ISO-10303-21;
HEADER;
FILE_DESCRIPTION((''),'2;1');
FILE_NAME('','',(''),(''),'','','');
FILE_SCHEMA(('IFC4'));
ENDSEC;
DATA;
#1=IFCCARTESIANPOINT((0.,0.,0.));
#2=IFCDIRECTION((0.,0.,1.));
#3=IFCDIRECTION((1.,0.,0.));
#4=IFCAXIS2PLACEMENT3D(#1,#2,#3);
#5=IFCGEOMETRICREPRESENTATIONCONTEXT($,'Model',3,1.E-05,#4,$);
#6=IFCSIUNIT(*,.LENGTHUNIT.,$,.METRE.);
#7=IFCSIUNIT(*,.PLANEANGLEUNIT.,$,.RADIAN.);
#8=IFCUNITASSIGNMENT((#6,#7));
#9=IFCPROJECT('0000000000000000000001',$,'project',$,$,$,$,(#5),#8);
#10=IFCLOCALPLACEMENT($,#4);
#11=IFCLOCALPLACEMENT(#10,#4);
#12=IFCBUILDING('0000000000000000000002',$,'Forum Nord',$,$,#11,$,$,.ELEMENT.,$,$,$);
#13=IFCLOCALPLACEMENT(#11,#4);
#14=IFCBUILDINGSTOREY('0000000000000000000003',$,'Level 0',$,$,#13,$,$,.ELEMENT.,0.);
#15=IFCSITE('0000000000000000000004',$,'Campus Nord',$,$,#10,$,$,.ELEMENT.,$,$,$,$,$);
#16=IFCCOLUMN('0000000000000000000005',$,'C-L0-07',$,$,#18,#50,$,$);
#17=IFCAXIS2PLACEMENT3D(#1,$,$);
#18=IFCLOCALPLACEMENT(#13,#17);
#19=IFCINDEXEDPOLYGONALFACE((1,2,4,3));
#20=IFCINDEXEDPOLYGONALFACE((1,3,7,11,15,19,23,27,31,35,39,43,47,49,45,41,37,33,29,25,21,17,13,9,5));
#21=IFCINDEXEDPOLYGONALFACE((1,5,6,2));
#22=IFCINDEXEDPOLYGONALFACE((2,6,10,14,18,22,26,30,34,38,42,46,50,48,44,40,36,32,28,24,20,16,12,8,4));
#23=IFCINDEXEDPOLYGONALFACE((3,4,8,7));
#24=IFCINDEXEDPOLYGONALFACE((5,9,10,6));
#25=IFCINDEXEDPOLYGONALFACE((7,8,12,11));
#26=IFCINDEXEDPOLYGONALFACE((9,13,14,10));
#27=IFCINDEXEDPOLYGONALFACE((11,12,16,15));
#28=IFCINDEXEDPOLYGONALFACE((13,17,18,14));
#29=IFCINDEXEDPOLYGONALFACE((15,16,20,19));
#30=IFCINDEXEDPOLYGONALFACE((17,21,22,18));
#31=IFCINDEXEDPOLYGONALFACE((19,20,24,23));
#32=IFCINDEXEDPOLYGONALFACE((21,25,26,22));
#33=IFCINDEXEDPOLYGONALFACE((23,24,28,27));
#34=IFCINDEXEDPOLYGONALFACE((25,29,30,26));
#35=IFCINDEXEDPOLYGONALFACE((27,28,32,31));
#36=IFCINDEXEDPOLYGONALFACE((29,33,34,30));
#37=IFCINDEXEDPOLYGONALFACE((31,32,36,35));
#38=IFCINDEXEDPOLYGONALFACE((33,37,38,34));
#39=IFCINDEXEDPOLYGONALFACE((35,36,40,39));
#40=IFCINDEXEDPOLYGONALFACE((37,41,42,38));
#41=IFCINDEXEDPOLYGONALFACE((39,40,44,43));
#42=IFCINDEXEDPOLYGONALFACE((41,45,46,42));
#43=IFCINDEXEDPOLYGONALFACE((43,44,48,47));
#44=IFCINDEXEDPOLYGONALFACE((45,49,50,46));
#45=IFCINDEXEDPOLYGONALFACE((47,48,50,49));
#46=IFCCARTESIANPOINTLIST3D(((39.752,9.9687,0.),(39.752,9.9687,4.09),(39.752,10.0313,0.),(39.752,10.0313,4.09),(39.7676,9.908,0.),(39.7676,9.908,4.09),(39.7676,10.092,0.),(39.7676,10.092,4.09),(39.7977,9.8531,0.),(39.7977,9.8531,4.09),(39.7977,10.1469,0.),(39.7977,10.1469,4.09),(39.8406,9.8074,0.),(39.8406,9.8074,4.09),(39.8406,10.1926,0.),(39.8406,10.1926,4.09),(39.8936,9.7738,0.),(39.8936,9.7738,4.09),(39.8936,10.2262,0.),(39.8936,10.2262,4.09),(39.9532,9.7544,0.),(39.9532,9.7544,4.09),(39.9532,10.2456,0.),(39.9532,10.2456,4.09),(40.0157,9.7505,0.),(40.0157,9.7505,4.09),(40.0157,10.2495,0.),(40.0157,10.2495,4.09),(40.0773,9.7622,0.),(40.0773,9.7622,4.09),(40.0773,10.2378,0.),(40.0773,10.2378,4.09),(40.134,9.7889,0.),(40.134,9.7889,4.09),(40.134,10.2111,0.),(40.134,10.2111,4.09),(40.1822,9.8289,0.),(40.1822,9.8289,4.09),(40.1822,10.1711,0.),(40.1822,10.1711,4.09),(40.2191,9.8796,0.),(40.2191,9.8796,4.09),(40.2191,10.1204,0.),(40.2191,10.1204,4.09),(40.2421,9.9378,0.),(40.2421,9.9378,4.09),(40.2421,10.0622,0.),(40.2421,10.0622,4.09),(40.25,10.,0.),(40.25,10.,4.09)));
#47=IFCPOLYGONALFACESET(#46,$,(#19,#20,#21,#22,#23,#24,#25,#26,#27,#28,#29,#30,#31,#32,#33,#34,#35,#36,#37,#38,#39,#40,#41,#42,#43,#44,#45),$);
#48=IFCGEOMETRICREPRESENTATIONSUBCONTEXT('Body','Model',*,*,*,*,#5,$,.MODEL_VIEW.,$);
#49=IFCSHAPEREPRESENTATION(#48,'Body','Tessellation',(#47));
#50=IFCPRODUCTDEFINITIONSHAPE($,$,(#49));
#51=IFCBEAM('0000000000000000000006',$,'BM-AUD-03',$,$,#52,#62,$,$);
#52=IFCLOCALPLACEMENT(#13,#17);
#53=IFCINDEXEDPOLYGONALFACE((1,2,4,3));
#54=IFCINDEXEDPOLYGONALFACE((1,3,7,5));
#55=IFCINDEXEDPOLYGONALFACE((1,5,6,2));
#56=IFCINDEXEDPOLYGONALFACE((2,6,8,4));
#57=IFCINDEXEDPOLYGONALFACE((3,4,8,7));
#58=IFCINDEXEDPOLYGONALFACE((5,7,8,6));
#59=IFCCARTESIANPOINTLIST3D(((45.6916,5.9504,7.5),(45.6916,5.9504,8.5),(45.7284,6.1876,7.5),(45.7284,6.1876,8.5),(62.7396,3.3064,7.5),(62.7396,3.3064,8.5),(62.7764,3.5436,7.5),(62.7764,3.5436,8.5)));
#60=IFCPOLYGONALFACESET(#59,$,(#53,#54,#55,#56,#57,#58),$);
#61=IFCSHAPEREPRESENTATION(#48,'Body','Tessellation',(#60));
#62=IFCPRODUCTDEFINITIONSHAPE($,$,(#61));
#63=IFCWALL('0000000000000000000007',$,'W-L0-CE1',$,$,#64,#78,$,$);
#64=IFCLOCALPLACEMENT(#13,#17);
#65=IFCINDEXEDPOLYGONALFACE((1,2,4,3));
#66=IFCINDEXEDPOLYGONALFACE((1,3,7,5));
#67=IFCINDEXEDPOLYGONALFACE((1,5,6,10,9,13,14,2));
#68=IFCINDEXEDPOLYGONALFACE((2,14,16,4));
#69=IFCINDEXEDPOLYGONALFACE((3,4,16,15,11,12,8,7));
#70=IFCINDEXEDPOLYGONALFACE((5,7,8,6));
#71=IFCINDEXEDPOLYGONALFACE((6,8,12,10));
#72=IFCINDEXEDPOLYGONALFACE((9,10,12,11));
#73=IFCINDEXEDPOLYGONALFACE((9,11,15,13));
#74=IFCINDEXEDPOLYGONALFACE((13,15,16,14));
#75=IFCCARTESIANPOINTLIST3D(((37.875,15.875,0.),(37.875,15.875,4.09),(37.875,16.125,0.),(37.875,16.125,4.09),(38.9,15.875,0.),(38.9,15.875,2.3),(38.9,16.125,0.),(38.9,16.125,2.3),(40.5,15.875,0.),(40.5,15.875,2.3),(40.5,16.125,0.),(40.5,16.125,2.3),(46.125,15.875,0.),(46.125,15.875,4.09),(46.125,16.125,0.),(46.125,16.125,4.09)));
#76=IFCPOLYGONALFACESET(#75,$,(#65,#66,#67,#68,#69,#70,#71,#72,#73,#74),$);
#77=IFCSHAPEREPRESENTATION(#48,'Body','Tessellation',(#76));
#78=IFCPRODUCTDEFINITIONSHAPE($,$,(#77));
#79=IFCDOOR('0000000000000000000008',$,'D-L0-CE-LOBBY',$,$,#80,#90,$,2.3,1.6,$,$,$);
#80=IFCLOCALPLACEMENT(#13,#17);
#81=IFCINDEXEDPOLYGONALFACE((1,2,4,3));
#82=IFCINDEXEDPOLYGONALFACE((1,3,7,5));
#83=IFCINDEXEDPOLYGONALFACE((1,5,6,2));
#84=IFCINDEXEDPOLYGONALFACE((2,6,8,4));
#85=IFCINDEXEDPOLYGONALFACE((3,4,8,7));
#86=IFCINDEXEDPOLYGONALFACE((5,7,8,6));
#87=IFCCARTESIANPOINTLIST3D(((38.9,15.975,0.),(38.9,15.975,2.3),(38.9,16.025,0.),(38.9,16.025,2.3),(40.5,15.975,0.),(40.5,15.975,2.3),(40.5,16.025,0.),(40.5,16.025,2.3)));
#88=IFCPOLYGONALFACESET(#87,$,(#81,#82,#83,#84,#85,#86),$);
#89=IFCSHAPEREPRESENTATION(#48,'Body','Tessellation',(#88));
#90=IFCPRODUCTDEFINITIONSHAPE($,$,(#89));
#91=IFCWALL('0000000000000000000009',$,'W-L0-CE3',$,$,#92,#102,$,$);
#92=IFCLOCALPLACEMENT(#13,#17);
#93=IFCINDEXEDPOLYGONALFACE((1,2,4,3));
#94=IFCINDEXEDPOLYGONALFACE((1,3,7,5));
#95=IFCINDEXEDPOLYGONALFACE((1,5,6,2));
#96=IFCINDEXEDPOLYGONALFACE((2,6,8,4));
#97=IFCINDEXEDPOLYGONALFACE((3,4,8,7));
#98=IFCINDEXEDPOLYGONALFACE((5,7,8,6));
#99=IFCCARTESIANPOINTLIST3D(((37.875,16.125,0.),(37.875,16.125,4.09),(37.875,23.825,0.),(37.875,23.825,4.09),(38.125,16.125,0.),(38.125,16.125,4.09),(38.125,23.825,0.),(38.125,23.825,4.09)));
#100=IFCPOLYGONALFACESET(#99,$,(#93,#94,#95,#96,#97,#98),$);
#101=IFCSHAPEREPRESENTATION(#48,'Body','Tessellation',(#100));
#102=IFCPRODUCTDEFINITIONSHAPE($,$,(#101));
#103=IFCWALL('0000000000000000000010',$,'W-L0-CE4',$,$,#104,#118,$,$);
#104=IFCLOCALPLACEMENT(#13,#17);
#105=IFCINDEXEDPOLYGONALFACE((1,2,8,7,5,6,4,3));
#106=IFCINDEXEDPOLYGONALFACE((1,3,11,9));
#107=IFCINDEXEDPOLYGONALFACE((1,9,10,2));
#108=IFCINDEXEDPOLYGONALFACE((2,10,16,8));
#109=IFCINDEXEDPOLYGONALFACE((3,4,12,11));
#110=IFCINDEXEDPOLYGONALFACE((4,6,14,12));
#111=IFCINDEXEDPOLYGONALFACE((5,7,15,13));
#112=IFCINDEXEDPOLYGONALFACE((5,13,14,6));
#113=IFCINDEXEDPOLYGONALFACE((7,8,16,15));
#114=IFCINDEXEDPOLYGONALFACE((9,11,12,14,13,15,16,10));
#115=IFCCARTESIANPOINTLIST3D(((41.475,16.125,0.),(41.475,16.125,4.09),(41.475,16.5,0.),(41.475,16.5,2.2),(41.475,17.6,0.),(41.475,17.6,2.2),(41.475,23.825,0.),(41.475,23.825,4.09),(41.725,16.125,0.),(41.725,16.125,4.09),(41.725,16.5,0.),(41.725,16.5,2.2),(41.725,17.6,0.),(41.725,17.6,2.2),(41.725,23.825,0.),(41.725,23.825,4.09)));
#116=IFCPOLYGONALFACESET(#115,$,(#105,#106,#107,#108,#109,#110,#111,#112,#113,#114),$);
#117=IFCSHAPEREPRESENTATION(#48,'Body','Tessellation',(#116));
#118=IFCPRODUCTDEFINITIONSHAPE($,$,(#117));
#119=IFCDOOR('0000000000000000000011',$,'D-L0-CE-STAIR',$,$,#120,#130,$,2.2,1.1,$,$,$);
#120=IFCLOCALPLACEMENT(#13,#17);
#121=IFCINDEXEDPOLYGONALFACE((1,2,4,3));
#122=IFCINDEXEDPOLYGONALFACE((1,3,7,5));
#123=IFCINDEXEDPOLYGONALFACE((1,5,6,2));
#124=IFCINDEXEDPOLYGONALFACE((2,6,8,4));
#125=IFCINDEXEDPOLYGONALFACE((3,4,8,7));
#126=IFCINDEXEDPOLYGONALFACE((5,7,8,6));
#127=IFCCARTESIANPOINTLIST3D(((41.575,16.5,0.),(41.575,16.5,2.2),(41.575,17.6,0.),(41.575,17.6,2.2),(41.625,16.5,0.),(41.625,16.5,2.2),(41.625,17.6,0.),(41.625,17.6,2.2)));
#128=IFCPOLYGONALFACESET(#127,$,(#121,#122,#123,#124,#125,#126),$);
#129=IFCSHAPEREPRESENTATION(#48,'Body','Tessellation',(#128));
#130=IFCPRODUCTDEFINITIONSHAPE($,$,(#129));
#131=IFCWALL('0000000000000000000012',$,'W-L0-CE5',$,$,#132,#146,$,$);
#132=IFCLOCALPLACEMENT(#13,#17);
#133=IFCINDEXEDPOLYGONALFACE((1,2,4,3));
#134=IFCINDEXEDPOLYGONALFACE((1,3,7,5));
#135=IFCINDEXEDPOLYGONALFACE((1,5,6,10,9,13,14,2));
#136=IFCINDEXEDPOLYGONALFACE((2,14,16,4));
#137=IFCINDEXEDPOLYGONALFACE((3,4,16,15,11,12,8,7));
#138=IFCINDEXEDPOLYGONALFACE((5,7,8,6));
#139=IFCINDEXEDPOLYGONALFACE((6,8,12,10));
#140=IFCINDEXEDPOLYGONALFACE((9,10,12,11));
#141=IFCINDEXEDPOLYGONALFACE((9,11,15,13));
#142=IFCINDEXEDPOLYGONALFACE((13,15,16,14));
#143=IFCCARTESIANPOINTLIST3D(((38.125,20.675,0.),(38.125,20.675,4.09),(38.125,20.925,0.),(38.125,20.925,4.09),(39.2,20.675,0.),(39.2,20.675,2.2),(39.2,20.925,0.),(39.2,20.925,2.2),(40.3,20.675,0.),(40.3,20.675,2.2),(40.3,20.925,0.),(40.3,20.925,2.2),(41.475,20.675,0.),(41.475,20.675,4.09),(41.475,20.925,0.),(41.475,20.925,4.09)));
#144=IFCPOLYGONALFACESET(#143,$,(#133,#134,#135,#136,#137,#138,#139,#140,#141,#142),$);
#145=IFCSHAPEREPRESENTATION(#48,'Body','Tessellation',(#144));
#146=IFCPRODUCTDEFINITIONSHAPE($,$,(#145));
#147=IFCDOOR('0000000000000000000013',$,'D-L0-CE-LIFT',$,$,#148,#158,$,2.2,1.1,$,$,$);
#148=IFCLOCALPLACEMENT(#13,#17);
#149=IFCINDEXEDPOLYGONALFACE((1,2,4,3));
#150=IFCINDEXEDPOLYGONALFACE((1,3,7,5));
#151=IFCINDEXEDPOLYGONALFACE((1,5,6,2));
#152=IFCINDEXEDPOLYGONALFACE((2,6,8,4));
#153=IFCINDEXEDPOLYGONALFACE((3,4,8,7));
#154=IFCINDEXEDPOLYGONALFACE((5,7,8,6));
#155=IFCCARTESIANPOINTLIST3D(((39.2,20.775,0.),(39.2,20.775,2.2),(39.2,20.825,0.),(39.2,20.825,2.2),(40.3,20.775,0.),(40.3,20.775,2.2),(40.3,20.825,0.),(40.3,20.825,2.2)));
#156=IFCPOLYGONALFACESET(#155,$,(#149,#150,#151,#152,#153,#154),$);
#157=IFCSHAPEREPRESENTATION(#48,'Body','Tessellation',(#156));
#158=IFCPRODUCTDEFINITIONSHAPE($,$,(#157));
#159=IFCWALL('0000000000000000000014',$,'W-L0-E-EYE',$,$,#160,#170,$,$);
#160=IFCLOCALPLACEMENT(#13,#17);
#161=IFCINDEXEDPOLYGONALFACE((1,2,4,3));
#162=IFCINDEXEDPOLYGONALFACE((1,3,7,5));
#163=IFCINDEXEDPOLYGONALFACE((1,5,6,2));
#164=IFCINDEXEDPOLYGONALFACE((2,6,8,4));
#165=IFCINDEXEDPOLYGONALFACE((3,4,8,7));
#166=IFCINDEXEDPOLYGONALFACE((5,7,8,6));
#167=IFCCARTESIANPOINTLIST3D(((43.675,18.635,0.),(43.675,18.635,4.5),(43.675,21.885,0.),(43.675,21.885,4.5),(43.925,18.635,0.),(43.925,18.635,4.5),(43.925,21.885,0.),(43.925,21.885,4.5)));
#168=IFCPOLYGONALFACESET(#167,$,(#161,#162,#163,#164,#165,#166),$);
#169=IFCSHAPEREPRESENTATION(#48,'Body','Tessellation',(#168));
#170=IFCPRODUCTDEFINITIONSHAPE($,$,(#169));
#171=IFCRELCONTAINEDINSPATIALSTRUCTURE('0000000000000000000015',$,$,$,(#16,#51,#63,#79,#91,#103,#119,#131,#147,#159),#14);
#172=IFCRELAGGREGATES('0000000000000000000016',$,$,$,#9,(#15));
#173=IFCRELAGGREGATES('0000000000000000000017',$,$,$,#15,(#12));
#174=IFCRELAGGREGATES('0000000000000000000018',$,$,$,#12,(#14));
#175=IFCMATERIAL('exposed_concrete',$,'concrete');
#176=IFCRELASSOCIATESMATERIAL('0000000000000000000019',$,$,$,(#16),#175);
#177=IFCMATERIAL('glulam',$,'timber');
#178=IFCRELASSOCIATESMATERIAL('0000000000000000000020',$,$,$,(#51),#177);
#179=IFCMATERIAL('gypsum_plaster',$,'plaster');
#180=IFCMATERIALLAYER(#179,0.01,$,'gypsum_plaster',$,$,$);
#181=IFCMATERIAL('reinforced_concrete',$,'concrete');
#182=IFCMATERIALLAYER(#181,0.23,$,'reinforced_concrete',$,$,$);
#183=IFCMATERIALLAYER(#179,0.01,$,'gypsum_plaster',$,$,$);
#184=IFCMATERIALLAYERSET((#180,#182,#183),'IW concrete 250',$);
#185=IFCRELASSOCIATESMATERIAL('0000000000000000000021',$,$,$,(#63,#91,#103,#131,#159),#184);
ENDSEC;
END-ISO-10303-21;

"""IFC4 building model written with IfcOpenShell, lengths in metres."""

from ifc_helpers import new_model, si_unit, frame, frame_2d, origin_with_axes, origin_2d_with_axis, place, context, subcontext, project, spatial, polyline, rectangle, circle, outline, extrude, material, layer, layer_set, layer_usage, element, fill, save


model = new_model("IFC4")

# Units and contexts
model_context = context("Model", 3, precision=1e-05, world=origin_with_axes())
body_context = subcontext(model_context, "Body", "Model", "MODEL_VIEW")
ifc_project = project(units=[si_unit("LENGTHUNIT", "METRE"), si_unit("PLANEANGLEUNIT", "RADIAN")], contexts=[model_context])

# Site, building, storey
site_placement = place(None, origin_with_axes())
site = spatial("IfcSite", under=ifc_project, at=site_placement, Name="Campus Nord", CompositionType="ELEMENT")
building_placement = place(site_placement, origin_with_axes())
building = spatial("IfcBuilding", under=site, at=building_placement, Name="Forum Nord", CompositionType="ELEMENT")
storey_placement = place(building_placement, origin_with_axes())
storey = spatial("IfcBuildingStorey", under=building, at=storey_placement, Name="Level 0", CompositionType="ELEMENT", Elevation=0.0)

# Column
ifc_material_1 = material(Name="exposed_concrete", Category="concrete")
column_placement = place(storey_placement, frame((40.0, 10.0, 0.0), z_axis=(0.0, 0.0, 1.0), x_axis=(1.0, 0.0, 0.0)))
element("IfcColumn", 1, at=column_placement, inside=storey, material=ifc_material_1, Name="C-L0-07", context=body_context, shape_type="SweptSolid", body=[
    extrude(circle(Radius=0.25, at=origin_2d_with_axis()), origin_with_axes(), (0.0, 0.0, 1.0), 4.09),
])

# Beam
ifc_material_2 = material(Name="glulam", Category="timber")
beam_placement = place(storey_placement, frame((45.71, 6.069, 8.0), z_axis=(0.98819, -0.15326, 0.0), x_axis=(0.15326, 0.98819, 0.0)))
element("IfcBeam", 2, at=beam_placement, inside=storey, material=ifc_material_2, Name="BM-AUD-03", context=body_context, shape_type="SweptSolid", body=[
    extrude(rectangle(XDim=0.24, YDim=1.0, at=origin_2d_with_axis()), origin_with_axes(), (0.0, 0.0, 1.0), 17.2518),
])

# Wall, opening, door
ifc_material_3 = material(Name="gypsum_plaster", Category="plaster")
ifc_layer_1 = layer(ifc_material_3, 0.01, Name="gypsum_plaster")
ifc_material_4 = material(Name="reinforced_concrete", Category="concrete")
ifc_layer_2 = layer(ifc_material_4, 0.23, Name="reinforced_concrete")
ifc_layer_3 = layer(ifc_material_3, 0.01, Name="gypsum_plaster")
ifc_layer_set = layer_set([ifc_layer_1, ifc_layer_2, ifc_layer_3], Name="IW concrete 250")
ifc_layer_usage = layer_usage(ifc_layer_set, "AXIS2", "POSITIVE", -0.125)
wall_1_placement = place(storey_placement, frame((37.875, 16.0, 0.0), z_axis=(0.0, 0.0, 1.0), x_axis=(1.0, 0.0, 0.0)))
wall_1 = element("IfcWall", 3, at=wall_1_placement, inside=storey, material=ifc_layer_usage, Name="W-L0-CE1", context=body_context, shape_type="SweptSolid", body=[
    extrude(rectangle(XDim=8.25, YDim=0.25, at=frame_2d((4.125, 0.0), x_axis=(1.0, 0.0))), origin_with_axes(), (0.0, 0.0, 1.0), 4.09),
])
opening_1_placement = place(storey_placement, frame((37.875, 16.0, 0.0), z_axis=(0.0, 0.0, 1.0), x_axis=(1.0, 0.0, 0.0)))
opening_1 = element("IfcOpeningElement", 4, at=opening_1_placement, cuts=wall_1, context=body_context, shape_type="SweptSolid", body=[
    extrude(rectangle(XDim=1.6, YDim=0.25, at=frame_2d((1.825, 0.0), x_axis=(1.0, 0.0))), origin_with_axes(), (0.0, 0.0, 1.0), 2.3),
])
door_1_placement = place(storey_placement, frame((37.875, 16.0, 0.0), z_axis=(0.0, 0.0, 1.0), x_axis=(1.0, 0.0, 0.0)))
door_1 = element("IfcDoor", 5, at=door_1_placement, inside=storey, Name="D-L0-CE-LOBBY", OverallHeight=2.3, OverallWidth=1.6, context=body_context, shape_type="SweptSolid", body=[
    extrude(rectangle(XDim=1.6, YDim=0.05, at=frame_2d((1.825, 0.0), x_axis=(1.0, 0.0))), origin_with_axes(), (0.0, 0.0, 1.0), 2.3),
])
fill(opening_1, door_1)

# Wall
wall_2_placement = place(storey_placement, frame((38.0, 16.125, 0.0), z_axis=(0.0, 0.0, 1.0), x_axis=(0.0, 1.0, 0.0)))
element("IfcWall", 6, at=wall_2_placement, inside=storey, material=ifc_layer_usage, Name="W-L0-CE3", context=body_context, shape_type="SweptSolid", body=[
    extrude(outline(polyline([(0.0, -0.125), (7.7, -0.125), (7.7, 0.125), (0.0, 0.125), (0.0, -0.125)])), origin_with_axes(), (0.0, 0.0, 1.0), 4.09),
])

# Walls, openings, doors
wall_3_placement = place(storey_placement, frame((41.6, 16.125, 0.0), z_axis=(0.0, 0.0, 1.0), x_axis=(0.0, 1.0, 0.0)))
wall_3 = element("IfcWall", 7, at=wall_3_placement, inside=storey, material=ifc_layer_usage, Name="W-L0-CE4", context=body_context, shape_type="SweptSolid", body=[
    extrude(outline(polyline([(0.0, -0.125), (7.7, -0.125), (7.7, 0.125), (0.0, 0.125), (0.0, -0.125)])), origin_with_axes(), (0.0, 0.0, 1.0), 4.09),
])
opening_2_placement = place(storey_placement, frame((41.6, 16.125, 0.0), z_axis=(0.0, 0.0, 1.0), x_axis=(0.0, 1.0, 0.0)))
opening_2 = element("IfcOpeningElement", 8, at=opening_2_placement, cuts=wall_3, context=body_context, shape_type="SweptSolid", body=[
    extrude(rectangle(XDim=1.1, YDim=0.25, at=frame_2d((0.925, 0.0), x_axis=(1.0, 0.0))), origin_with_axes(), (0.0, 0.0, 1.0), 2.2),
])
door_2_placement = place(storey_placement, frame((41.6, 16.125, 0.0), z_axis=(0.0, 0.0, 1.0), x_axis=(0.0, 1.0, 0.0)))
door_2 = element("IfcDoor", 9, at=door_2_placement, inside=storey, Name="D-L0-CE-STAIR", OverallHeight=2.2, OverallWidth=1.1, context=body_context, shape_type="SweptSolid", body=[
    extrude(rectangle(XDim=1.1, YDim=0.05, at=frame_2d((0.925, 0.0), x_axis=(1.0, 0.0))), origin_with_axes(), (0.0, 0.0, 1.0), 2.2),
])
fill(opening_2, door_2)
wall_4_placement = place(storey_placement, frame((38.125, 20.8, 0.0), z_axis=(0.0, 0.0, 1.0), x_axis=(1.0, 0.0, 0.0)))
wall_4 = element("IfcWall", 10, at=wall_4_placement, inside=storey, material=ifc_layer_usage, Name="W-L0-CE5", context=body_context, shape_type="SweptSolid", body=[
    extrude(outline(polyline([(0.0, -0.125), (3.35, -0.125), (3.35, 0.125), (0.0, 0.125), (0.0, -0.125)])), origin_with_axes(), (0.0, 0.0, 1.0), 4.09),
])
opening_3_placement = place(storey_placement, frame((38.125, 20.8, 0.0), z_axis=(0.0, 0.0, 1.0), x_axis=(1.0, 0.0, 0.0)))
opening_3 = element("IfcOpeningElement", 11, at=opening_3_placement, cuts=wall_4, context=body_context, shape_type="SweptSolid", body=[
    extrude(rectangle(XDim=1.1, YDim=0.25, at=frame_2d((1.625, 0.0), x_axis=(1.0, 0.0))), origin_with_axes(), (0.0, 0.0, 1.0), 2.2),
])
door_3_placement = place(storey_placement, frame((38.125, 20.8, 0.0), z_axis=(0.0, 0.0, 1.0), x_axis=(1.0, 0.0, 0.0)))
door_3 = element("IfcDoor", 12, at=door_3_placement, inside=storey, Name="D-L0-CE-LIFT", OverallHeight=2.2, OverallWidth=1.1, context=body_context, shape_type="SweptSolid", body=[
    extrude(rectangle(XDim=1.1, YDim=0.05, at=frame_2d((1.625, 0.0), x_axis=(1.0, 0.0))), origin_with_axes(), (0.0, 0.0, 1.0), 2.2),
])
fill(opening_3, door_3)

# Wall
wall_5_placement = place(storey_placement, frame((43.8, 18.635, 0.0), z_axis=(0.0, 0.0, 1.0), x_axis=(0.0, 1.0, 0.0)))
element("IfcWall", 13, at=wall_5_placement, inside=storey, material=ifc_layer_usage, Name="W-L0-E-EYE", context=body_context, shape_type="SweptSolid", body=[
    extrude(rectangle(XDim=3.25, YDim=0.25, at=frame_2d((1.625, 0.0), x_axis=(1.0, 0.0))), origin_with_axes(), (0.0, 0.0, 1.0), 4.5),
])

save(model, "model.ifc")
